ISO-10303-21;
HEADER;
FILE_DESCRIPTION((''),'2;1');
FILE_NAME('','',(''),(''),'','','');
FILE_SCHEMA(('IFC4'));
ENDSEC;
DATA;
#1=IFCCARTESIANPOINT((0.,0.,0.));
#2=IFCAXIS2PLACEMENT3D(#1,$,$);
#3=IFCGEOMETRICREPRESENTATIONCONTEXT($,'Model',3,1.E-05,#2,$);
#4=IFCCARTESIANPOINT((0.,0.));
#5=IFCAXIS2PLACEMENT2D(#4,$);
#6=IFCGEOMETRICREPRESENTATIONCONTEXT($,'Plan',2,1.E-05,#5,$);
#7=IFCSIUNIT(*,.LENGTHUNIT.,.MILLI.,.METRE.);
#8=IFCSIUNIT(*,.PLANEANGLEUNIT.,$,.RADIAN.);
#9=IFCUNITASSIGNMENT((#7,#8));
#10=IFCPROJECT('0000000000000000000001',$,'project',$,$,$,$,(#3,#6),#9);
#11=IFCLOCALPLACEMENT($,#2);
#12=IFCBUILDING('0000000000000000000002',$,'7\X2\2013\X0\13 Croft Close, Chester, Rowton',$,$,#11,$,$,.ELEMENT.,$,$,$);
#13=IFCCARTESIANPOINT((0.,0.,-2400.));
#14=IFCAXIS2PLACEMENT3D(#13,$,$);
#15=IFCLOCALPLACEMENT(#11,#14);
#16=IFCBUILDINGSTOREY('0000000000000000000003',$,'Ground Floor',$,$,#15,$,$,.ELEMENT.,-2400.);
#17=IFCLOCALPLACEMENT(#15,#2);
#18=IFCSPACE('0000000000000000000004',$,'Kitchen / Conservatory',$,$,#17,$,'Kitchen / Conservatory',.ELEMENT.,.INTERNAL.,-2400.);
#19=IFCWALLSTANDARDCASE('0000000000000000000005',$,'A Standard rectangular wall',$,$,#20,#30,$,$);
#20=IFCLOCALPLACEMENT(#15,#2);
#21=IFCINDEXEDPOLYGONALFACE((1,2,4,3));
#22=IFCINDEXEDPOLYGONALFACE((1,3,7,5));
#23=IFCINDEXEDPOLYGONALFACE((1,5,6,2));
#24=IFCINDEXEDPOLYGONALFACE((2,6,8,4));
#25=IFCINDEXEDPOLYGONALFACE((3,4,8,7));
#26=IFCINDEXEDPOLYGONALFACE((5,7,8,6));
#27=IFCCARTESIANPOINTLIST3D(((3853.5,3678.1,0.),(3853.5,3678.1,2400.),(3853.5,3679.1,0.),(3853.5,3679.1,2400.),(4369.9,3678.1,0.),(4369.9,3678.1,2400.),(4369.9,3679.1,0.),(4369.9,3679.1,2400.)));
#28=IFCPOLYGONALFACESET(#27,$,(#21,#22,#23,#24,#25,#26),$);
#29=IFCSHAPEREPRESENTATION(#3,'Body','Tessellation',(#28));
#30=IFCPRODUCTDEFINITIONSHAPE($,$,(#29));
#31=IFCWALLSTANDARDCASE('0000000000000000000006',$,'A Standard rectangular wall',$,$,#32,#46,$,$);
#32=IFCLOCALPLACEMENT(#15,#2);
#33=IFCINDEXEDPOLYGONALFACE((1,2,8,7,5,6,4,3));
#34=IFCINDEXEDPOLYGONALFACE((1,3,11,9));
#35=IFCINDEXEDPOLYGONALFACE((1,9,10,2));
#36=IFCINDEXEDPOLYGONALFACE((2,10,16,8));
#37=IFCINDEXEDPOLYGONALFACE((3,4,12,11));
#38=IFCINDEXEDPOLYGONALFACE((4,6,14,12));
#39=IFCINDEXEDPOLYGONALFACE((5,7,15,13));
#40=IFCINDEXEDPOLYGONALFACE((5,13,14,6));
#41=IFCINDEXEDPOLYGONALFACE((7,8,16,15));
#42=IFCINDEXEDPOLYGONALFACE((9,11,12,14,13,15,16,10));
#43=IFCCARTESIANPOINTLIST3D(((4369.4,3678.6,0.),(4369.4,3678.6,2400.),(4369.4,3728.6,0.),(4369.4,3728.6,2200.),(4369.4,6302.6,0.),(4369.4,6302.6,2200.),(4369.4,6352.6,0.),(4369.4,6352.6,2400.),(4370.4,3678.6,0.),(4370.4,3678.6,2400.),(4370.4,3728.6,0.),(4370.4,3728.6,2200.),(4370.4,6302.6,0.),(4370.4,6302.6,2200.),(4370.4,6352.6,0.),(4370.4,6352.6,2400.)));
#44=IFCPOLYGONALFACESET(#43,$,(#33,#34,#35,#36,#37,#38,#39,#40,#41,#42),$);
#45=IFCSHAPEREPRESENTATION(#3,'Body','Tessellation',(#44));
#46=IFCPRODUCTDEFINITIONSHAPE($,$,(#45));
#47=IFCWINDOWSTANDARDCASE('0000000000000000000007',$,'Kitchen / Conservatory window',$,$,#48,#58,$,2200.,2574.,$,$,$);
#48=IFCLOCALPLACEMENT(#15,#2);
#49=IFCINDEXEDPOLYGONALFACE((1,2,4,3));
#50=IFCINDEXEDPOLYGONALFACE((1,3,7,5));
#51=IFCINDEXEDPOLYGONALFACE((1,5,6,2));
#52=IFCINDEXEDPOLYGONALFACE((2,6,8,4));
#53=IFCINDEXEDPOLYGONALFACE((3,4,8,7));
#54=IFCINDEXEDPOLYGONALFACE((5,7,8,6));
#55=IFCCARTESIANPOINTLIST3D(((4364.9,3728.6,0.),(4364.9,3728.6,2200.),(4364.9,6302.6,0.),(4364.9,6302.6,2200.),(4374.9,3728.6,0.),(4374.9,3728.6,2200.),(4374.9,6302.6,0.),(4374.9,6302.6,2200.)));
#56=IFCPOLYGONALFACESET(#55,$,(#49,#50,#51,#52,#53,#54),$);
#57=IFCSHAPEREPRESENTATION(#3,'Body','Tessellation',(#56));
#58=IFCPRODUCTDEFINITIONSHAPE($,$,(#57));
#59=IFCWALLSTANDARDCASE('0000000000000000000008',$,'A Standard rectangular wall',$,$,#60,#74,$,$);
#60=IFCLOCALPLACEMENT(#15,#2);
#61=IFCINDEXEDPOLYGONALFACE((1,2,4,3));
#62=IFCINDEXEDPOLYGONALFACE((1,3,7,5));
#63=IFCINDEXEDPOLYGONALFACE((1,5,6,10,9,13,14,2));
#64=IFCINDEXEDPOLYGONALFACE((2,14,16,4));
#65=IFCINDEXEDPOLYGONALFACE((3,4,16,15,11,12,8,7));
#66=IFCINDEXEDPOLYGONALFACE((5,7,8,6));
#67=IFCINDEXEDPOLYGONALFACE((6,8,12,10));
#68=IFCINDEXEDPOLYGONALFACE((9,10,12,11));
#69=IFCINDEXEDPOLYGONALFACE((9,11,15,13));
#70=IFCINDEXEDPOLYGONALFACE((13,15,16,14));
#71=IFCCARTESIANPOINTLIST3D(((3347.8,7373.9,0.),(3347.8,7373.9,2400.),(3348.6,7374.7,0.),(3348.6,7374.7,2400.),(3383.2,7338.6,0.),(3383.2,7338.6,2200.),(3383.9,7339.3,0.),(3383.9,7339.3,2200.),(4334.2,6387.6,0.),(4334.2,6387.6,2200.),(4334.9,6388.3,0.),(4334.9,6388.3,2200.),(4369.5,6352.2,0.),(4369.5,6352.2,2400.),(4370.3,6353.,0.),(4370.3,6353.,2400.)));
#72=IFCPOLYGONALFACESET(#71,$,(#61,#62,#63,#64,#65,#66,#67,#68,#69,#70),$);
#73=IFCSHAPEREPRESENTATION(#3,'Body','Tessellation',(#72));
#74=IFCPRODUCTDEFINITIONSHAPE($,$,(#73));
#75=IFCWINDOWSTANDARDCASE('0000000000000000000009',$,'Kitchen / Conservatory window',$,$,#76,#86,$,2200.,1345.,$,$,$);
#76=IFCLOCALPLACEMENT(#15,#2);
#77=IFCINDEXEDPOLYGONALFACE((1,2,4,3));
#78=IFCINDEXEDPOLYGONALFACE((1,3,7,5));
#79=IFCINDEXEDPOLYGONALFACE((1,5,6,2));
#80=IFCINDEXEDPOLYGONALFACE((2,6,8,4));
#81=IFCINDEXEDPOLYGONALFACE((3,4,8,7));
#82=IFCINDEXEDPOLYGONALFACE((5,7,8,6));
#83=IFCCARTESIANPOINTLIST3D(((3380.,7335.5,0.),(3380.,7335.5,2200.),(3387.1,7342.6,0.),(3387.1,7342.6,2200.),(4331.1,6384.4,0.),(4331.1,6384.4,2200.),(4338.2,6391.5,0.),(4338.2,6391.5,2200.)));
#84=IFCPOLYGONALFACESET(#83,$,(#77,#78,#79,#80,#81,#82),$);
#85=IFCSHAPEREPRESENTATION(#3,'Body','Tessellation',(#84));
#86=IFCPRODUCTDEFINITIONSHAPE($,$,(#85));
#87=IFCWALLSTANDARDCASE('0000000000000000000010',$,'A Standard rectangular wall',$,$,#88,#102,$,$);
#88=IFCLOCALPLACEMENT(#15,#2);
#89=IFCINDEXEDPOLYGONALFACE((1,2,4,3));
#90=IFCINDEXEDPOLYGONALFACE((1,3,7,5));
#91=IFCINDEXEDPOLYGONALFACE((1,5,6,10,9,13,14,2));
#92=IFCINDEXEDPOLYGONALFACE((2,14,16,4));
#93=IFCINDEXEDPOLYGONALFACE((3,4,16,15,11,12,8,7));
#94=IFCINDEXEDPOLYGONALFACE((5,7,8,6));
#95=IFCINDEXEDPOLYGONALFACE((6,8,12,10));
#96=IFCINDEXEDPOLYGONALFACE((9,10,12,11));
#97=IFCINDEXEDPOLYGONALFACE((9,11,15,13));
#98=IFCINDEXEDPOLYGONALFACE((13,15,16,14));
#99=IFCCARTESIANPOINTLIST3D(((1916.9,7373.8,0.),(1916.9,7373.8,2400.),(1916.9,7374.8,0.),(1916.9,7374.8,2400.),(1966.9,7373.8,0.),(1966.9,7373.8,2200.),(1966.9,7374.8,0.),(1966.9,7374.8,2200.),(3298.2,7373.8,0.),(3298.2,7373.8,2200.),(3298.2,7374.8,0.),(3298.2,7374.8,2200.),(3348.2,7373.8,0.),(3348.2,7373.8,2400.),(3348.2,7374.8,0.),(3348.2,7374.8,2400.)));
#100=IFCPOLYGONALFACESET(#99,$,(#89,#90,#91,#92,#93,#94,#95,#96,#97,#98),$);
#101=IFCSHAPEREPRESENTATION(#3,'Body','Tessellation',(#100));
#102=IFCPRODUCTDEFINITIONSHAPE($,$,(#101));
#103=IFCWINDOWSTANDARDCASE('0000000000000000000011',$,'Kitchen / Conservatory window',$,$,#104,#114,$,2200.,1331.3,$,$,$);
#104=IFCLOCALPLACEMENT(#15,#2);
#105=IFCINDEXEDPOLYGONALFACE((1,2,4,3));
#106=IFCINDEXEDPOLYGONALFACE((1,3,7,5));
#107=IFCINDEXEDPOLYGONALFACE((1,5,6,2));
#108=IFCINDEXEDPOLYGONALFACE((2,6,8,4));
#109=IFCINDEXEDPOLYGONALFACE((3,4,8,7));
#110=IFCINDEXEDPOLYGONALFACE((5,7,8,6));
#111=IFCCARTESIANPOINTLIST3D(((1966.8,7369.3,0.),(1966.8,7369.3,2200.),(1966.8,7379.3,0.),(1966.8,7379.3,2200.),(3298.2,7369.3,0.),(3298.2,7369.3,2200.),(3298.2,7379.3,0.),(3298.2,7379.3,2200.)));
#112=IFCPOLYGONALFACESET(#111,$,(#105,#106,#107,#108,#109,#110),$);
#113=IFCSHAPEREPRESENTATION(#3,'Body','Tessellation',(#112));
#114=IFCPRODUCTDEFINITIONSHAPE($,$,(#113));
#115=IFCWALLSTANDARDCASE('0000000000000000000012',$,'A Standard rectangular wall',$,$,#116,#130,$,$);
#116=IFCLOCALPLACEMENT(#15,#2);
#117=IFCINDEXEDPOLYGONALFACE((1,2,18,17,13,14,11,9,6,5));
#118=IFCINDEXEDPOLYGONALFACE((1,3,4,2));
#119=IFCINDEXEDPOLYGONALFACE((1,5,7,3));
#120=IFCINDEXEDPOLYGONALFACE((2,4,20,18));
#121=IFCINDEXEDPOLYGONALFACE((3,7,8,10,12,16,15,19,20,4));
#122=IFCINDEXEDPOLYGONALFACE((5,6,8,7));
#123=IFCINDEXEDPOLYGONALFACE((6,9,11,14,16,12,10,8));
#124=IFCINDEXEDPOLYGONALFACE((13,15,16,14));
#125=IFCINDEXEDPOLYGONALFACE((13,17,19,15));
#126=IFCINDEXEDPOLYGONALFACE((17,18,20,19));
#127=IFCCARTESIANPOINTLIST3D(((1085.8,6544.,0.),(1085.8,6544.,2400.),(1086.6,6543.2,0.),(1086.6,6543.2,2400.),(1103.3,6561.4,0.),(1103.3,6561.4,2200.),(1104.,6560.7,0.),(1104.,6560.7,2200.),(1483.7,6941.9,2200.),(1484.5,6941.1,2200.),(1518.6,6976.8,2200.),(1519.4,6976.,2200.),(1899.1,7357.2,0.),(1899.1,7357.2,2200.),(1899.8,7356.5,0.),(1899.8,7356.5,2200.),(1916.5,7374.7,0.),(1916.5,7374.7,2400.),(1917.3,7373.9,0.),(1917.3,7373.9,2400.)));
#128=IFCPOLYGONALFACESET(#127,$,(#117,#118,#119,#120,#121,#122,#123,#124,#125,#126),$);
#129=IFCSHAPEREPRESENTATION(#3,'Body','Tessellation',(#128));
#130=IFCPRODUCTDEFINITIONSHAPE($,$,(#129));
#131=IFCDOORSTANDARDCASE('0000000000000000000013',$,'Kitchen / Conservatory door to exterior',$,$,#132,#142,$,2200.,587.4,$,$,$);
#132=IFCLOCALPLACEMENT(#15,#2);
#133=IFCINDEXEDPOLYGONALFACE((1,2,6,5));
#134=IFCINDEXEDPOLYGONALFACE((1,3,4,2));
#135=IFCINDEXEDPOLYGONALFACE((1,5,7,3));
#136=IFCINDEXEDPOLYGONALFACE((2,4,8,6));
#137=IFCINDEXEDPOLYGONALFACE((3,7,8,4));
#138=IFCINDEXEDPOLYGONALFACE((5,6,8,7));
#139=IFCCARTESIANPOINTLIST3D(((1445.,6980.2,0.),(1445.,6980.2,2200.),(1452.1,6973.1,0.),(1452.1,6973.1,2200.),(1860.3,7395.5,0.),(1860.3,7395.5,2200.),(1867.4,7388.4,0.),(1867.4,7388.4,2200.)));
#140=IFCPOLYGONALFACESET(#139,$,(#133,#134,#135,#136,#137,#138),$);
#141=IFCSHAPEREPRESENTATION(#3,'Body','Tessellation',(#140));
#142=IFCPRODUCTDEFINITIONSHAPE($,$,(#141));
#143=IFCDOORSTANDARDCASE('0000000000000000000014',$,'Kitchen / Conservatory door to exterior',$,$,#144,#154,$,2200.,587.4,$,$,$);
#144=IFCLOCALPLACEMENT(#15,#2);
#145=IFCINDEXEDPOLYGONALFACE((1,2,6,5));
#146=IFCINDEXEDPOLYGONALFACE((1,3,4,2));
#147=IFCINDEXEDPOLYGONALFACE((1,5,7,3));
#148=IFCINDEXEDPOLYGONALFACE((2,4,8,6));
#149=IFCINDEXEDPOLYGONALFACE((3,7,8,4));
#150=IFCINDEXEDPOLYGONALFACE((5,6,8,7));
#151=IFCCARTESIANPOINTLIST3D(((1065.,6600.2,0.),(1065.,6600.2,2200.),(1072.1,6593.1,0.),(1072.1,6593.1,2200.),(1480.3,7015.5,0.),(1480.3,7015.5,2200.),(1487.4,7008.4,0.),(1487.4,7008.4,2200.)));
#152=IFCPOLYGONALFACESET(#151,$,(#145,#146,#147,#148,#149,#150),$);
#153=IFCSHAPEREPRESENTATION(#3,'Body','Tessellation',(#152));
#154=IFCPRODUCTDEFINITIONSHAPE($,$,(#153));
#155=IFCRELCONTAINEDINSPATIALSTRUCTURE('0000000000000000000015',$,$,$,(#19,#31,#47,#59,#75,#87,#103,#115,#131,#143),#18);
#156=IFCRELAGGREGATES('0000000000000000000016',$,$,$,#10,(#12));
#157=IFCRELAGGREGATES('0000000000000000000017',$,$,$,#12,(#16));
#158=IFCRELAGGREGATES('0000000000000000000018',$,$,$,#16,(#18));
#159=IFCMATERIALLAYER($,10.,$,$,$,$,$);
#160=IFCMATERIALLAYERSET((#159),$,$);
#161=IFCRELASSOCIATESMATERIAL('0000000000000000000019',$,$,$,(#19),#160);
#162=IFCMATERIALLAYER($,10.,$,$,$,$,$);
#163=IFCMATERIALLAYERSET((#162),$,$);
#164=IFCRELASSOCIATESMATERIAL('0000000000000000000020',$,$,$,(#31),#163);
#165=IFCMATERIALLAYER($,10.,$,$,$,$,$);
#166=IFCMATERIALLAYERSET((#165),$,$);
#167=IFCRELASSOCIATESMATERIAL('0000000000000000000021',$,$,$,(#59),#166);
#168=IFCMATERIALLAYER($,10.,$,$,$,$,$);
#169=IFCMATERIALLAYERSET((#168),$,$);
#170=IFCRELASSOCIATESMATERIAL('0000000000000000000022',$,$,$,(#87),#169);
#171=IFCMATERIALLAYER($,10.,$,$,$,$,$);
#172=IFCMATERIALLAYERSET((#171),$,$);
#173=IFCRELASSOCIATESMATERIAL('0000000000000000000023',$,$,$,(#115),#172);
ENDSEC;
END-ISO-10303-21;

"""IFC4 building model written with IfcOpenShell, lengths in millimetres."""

from ifc_helpers import new_model, si_unit, frame, origin, origin_2d, place, context, project, spatial, rectangle, extrude, layer, layer_set, layer_usage, element, fill, save


model = new_model("IFC4")

# Units and contexts
model_context = context("Model", 3, precision=1e-05, world=origin())
plan_context = context("Plan", 2, precision=1e-05, world=origin_2d())
ifc_project = project(units=[si_unit("LENGTHUNIT", "METRE", prefix="MILLI"), si_unit("PLANEANGLEUNIT", "RADIAN")], contexts=[model_context, plan_context])

# Building, storey, space
building_placement = place(None, origin())
building = spatial("IfcBuilding", under=ifc_project, at=building_placement, Name="7–13 Croft Close, Chester, Rowton", CompositionType="ELEMENT")
storey_placement = place(building_placement, frame((0.0, 0.0, -2400.0)))
storey = spatial("IfcBuildingStorey", under=building, at=storey_placement, Name="Ground Floor", CompositionType="ELEMENT", Elevation=-2400.0)
space_placement = place(storey_placement, origin())
space = spatial("IfcSpace", under=storey, at=space_placement, Name="Kitchen / Conservatory", LongName="Kitchen / Conservatory", CompositionType="ELEMENT", PredefinedType="INTERNAL", ElevationWithFlooring=-2400.0)

# Wall
ifc_layer_1 = layer(None, 10.0)
ifc_layer_set_1 = layer_set([ifc_layer_1])
ifc_layer_usage_1 = layer_usage(ifc_layer_set_1, "AXIS2", "NEGATIVE", 150.0)
wall_1_placement = place(storey_placement, origin())
element("IfcWallStandardCase", 1, at=wall_1_placement, inside=space, material=ifc_layer_usage_1, Name="A Standard rectangular wall", context=model_context, shape_type="SweptSolid", body=[
    extrude(rectangle(XDim=1.0, YDim=516.4, at=origin_2d()), frame((4111.7, 3678.6, 0.0), x_axis=(0.0, 1.0, 0.0)), (0.0, 0.0, 1.0), 2400.0),
])

# Walls, openings, windows
ifc_layer_2 = layer(None, 10.0)
ifc_layer_set_2 = layer_set([ifc_layer_2])
ifc_layer_usage_2 = layer_usage(ifc_layer_set_2, "AXIS2", "NEGATIVE", 150.0)
wall_2_placement = place(storey_placement, origin())
wall_2 = element("IfcWallStandardCase", 2, at=wall_2_placement, inside=space, material=ifc_layer_usage_2, Name="A Standard rectangular wall", context=model_context, shape_type="SweptSolid", body=[
    extrude(rectangle(XDim=1.0, YDim=2674.0, at=origin_2d()), frame((4369.9, 5015.6, 0.0), x_axis=(-1.0, 0.0, 0.0)), (0.0, 0.0, 1.0), 2400.0),
])
opening_1_placement = place(storey_placement, origin())
opening_1 = element("IfcOpeningElement", 3, at=opening_1_placement, cuts=wall_2, context=model_context, shape_type="SweptSolid", body=[
    extrude(rectangle(XDim=10.0, YDim=2574.0, at=origin_2d()), frame((4369.9, 5015.6, 0.0), x_axis=(-1.0, 0.0, 0.0)), (0.0, 0.0, 1.0), 2200.0),
])
window_1_placement = place(storey_placement, origin())
window_1 = element("IfcWindowStandardCase", 4, at=window_1_placement, inside=space, Name="Kitchen / Conservatory window", OverallHeight=2200.0, OverallWidth=2574.0, context=model_context, shape_type="SweptSolid", body=[
    extrude(rectangle(XDim=10.0, YDim=2574.0, at=origin_2d()), frame((4369.9, 5015.6, 0.0), x_axis=(-1.0, 0.0, 0.0)), (0.0, 0.0, 1.0), 2200.0),
])
fill(opening_1, window_1)
ifc_layer_3 = layer(None, 10.0)
ifc_layer_set_3 = layer_set([ifc_layer_3])
ifc_layer_usage_3 = layer_usage(ifc_layer_set_3, "AXIS2", "NEGATIVE", 150.0)
wall_3_placement = place(storey_placement, origin())
wall_3 = element("IfcWallStandardCase", 5, at=wall_3_placement, inside=space, material=ifc_layer_usage_3, Name="A Standard rectangular wall", context=model_context, shape_type="SweptSolid", body=[
    extrude(rectangle(XDim=1.0, YDim=1444.9, at=origin_2d()), frame((3859.1, 6863.5, 0.0), x_axis=(-0.707107, -0.707107, 0.0)), (0.0, 0.0, 1.0), 2400.0),
])
opening_2_placement = place(storey_placement, origin())
opening_2 = element("IfcOpeningElement", 6, at=opening_2_placement, cuts=wall_3, context=model_context, shape_type="SweptSolid", body=[
    extrude(rectangle(XDim=10.0, YDim=1345.0, at=origin_2d()), frame((3859.1, 6863.5, 0.0), x_axis=(-0.707107, -0.707107, 0.0)), (0.0, 0.0, 1.0), 2200.0),
])
window_2_placement = place(storey_placement, frame((0.0, 0.1, 0.0)))
window_2 = element("IfcWindowStandardCase", 7, at=window_2_placement, inside=space, Name="Kitchen / Conservatory window", OverallHeight=2200.0, OverallWidth=1345.0, context=model_context, shape_type="SweptSolid", body=[
    extrude(rectangle(XDim=10.0, YDim=1345.0, at=origin_2d()), frame((3859.1, 6863.5, 0.0), x_axis=(-0.707107, -0.707107, 0.0)), (0.0, 0.0, 1.0), 2200.0),
])
fill(opening_2, window_2)
ifc_layer_4 = layer(None, 10.0)
ifc_layer_set_4 = layer_set([ifc_layer_4])
ifc_layer_usage_4 = layer_usage(ifc_layer_set_4, "AXIS2", "NEGATIVE", 150.0)
wall_4_placement = place(storey_placement, origin())
wall_4 = element("IfcWallStandardCase", 8, at=wall_4_placement, inside=space, material=ifc_layer_usage_4, Name="A Standard rectangular wall", context=model_context, shape_type="SweptSolid", body=[
    extrude(rectangle(XDim=1.0, YDim=1431.3, at=origin_2d()), frame((2632.6, 7374.3, 0.0), x_axis=(0.0, -1.0, 0.0)), (0.0, 0.0, 1.0), 2400.0),
])
opening_3_placement = place(storey_placement, origin())
opening_3 = element("IfcOpeningElement", 9, at=opening_3_placement, cuts=wall_4, context=model_context, shape_type="SweptSolid", body=[
    extrude(rectangle(XDim=10.0, YDim=1331.3, at=origin_2d()), frame((2632.6, 7374.3, 0.0), x_axis=(0.0, -1.0, 0.0)), (0.0, 0.0, 1.0), 2200.0),
])
window_3_placement = place(storey_placement, frame((-0.1, 0.0, 0.0)))
window_3 = element("IfcWindowStandardCase", 10, at=window_3_placement, inside=space, Name="Kitchen / Conservatory window", OverallHeight=2200.0, OverallWidth=1331.3, context=model_context, shape_type="SweptSolid", body=[
    extrude(rectangle(XDim=10.0, YDim=1331.3, at=origin_2d()), frame((2632.6, 7374.3, 0.0), x_axis=(0.0, -1.0, 0.0)), (0.0, 0.0, 1.0), 2200.0),
])
fill(opening_3, window_3)

# Wall, openings, doors
ifc_layer_5 = layer(None, 10.0)
ifc_layer_set_5 = layer_set([ifc_layer_5])
ifc_layer_usage_5 = layer_usage(ifc_layer_set_5, "AXIS2", "NEGATIVE", 150.0)
wall_5_placement = place(storey_placement, origin())
wall_5 = element("IfcWallStandardCase", 11, at=wall_5_placement, inside=space, material=ifc_layer_usage_5, Name="A Standard rectangular wall", context=model_context, shape_type="SweptSolid", body=[
    extrude(rectangle(XDim=1.0, YDim=1174.8, at=origin_2d()), frame((1501.6, 6959.0, 0.0), x_axis=(0.707107, -0.707107, 0.0)), (0.0, 0.0, 1.0), 2400.0),
])
opening_4_placement = place(storey_placement, origin())
opening_4 = element("IfcOpeningElement", 12, at=opening_4_placement, cuts=wall_5, context=model_context, shape_type="SweptSolid", body=[
    extrude(rectangle(XDim=10.0, YDim=587.4, at=origin_2d()), frame((1691.8, 7149.2, 0.0), x_axis=(0.707107, -0.707107, 0.0)), (0.0, 0.0, 1.0), 2200.0),
])
opening_5_placement = place(storey_placement, origin())
opening_5 = element("IfcOpeningElement", 13, at=opening_5_placement, cuts=wall_5, context=model_context, shape_type="SweptSolid", body=[
    extrude(rectangle(XDim=10.0, YDim=587.4, at=origin_2d()), frame((1311.3, 6768.7, 0.0), x_axis=(0.707107, -0.707107, 0.0)), (0.0, 0.0, 1.0), 2200.0),
])
door_1_placement = place(storey_placement, frame((-35.6, 35.1, 0.0)))
door_1 = element("IfcDoorStandardCase", 14, at=door_1_placement, inside=space, Name="Kitchen / Conservatory door to exterior", OverallHeight=2200.0, OverallWidth=587.4, context=model_context, shape_type="SweptSolid", body=[
    extrude(rectangle(XDim=10.0, YDim=587.4, at=origin_2d()), frame((1691.8, 7149.2, 0.0), x_axis=(0.707107, -0.707107, 0.0)), (0.0, 0.0, 1.0), 2200.0),
])
fill(opening_4, door_1)
door_2_placement = place(storey_placement, frame((-35.1, 35.6, 0.0)))
door_2 = element("IfcDoorStandardCase", 15, at=door_2_placement, inside=space, Name="Kitchen / Conservatory door to exterior", OverallHeight=2200.0, OverallWidth=587.4, context=model_context, shape_type="SweptSolid", body=[
    extrude(rectangle(XDim=10.0, YDim=587.4, at=origin_2d()), frame((1311.3, 6768.7, 0.0), x_axis=(0.707107, -0.707107, 0.0)), (0.0, 0.0, 1.0), 2200.0),
])
fill(opening_5, door_2)

save(model, "model.ifc")
